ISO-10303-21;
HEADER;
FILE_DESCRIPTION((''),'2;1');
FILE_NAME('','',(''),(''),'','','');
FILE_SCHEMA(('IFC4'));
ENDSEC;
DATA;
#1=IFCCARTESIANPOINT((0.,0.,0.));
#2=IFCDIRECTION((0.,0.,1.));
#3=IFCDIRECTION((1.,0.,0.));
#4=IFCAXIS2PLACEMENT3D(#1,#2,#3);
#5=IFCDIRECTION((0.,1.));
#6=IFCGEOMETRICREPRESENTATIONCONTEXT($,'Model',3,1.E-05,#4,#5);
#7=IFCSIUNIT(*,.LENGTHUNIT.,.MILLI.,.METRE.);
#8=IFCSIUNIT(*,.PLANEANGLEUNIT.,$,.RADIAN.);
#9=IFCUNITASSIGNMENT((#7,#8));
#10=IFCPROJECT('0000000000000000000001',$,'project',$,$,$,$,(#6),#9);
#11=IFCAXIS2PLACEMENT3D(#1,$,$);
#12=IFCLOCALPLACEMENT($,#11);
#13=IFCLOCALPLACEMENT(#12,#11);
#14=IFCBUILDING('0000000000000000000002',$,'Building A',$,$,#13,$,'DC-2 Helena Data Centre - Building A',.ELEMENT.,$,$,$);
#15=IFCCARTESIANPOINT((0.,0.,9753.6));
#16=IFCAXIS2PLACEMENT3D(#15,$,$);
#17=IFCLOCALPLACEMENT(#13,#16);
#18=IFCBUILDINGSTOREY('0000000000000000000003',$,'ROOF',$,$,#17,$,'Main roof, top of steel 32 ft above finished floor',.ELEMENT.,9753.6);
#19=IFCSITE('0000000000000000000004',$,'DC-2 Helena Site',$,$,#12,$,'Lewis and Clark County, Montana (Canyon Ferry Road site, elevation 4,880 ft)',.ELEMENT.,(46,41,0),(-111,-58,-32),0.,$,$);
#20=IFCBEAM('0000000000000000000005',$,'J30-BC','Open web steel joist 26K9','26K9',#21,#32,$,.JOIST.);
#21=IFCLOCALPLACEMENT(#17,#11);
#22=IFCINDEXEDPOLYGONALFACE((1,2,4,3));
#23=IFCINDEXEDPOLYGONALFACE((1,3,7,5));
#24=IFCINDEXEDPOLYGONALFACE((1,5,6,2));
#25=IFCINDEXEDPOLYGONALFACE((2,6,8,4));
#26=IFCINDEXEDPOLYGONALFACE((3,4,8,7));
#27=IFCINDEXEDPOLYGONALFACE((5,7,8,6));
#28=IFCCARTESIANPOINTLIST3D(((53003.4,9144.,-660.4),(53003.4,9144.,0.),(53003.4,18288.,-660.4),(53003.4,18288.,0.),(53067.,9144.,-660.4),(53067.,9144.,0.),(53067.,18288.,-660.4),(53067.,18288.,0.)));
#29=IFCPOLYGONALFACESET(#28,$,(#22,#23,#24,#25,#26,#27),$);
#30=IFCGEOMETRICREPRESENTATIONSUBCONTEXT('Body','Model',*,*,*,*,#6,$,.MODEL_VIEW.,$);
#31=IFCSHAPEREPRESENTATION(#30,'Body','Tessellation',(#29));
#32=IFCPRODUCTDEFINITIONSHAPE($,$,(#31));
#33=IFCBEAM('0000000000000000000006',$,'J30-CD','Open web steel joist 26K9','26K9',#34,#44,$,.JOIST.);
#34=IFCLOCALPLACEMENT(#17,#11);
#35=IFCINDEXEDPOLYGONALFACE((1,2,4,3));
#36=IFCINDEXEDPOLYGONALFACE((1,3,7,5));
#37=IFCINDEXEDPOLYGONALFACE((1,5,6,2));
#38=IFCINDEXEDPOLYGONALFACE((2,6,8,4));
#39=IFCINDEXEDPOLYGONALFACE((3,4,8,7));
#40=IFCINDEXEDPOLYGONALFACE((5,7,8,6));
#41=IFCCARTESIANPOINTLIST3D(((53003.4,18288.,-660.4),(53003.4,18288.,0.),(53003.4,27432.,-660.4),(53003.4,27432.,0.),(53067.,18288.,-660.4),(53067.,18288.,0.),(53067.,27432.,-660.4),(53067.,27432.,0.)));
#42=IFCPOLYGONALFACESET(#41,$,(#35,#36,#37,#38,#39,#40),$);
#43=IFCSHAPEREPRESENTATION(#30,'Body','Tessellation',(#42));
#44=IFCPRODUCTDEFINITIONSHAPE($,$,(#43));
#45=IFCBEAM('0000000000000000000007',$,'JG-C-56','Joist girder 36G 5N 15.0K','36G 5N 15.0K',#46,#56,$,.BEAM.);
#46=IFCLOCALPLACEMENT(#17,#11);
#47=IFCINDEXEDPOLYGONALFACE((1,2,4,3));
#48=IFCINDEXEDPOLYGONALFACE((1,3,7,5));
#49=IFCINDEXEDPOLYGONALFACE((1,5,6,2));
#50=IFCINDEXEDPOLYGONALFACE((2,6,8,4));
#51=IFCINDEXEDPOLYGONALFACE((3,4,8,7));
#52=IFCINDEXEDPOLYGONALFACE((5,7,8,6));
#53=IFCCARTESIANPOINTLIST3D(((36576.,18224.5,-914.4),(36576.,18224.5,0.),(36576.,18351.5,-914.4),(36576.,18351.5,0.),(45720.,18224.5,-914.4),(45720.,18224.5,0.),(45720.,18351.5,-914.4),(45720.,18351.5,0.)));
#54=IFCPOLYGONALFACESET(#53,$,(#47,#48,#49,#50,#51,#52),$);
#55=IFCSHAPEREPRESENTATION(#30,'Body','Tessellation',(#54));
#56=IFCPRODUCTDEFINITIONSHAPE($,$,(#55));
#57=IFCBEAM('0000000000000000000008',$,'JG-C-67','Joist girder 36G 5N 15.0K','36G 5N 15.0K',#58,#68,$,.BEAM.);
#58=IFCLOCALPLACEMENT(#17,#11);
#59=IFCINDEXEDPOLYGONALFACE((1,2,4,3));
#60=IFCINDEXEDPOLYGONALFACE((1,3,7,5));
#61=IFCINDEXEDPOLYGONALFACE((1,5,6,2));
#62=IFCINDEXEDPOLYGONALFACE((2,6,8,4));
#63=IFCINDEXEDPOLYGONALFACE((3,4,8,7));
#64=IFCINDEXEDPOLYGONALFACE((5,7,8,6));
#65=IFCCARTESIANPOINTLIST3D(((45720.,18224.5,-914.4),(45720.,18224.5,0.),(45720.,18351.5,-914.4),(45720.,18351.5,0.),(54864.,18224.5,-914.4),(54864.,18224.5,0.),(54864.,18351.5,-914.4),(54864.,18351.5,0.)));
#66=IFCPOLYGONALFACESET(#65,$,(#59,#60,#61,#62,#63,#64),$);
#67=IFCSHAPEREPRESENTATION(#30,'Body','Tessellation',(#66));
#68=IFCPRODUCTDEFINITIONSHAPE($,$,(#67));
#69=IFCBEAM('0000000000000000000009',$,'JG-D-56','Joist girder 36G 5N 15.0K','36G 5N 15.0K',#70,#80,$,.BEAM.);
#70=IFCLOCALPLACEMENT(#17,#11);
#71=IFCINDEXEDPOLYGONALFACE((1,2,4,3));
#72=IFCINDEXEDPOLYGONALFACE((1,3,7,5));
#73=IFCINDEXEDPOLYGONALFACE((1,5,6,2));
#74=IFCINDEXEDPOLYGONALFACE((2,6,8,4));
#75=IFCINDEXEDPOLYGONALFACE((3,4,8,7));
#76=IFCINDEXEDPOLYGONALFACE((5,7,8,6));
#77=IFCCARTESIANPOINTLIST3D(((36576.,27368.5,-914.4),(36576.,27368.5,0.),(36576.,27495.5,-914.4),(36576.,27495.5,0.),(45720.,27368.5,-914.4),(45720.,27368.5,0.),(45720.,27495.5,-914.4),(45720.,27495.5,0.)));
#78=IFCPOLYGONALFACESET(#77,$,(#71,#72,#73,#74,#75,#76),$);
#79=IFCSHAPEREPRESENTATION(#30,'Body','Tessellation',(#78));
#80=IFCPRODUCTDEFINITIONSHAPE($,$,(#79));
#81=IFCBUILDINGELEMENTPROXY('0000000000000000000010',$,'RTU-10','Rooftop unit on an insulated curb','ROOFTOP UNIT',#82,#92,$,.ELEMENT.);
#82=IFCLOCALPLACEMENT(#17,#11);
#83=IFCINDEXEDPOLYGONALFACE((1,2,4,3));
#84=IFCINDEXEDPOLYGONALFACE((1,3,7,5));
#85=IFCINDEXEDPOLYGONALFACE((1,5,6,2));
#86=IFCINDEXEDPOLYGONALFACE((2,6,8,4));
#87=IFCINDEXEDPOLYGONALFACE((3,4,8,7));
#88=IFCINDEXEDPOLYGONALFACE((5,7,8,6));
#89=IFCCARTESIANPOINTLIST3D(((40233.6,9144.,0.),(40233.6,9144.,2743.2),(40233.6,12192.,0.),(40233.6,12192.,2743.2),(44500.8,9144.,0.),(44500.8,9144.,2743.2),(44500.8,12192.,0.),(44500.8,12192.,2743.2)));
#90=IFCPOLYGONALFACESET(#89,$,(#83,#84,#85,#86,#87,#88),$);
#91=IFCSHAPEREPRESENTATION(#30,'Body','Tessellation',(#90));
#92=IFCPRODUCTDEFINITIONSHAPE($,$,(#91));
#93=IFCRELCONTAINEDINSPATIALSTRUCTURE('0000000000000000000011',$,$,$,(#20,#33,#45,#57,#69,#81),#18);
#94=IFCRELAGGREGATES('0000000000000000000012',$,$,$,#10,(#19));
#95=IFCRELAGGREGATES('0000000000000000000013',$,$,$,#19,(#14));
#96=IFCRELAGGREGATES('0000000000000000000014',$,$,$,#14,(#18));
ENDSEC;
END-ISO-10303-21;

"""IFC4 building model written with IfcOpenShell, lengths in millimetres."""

from ifc_helpers import new_model, si_unit, direction, frame, origin, origin_with_axes, origin_2d, place, context, subcontext, project, spatial, rectangle, extrude, element, save


model = new_model("IFC4")

# Units and contexts
model_context = context("Model", 3, precision=1e-05, world=origin_with_axes(), true_north=direction((0.0, 1.0)))
body_context = subcontext(model_context, "Body", "Model", "MODEL_VIEW")
ifc_project = project(units=[si_unit("LENGTHUNIT", "METRE", prefix="MILLI"), si_unit("PLANEANGLEUNIT", "RADIAN")], contexts=[model_context])

# Site, building, storey
site_placement = place(None, origin())
site = spatial("IfcSite", under=ifc_project, at=site_placement, Name="DC-2 Helena Site", LongName="Lewis and Clark County, Montana (Canyon Ferry Road site, elevation 4,880 ft)", CompositionType="ELEMENT", RefLatitude=(46, 41, 0), RefLongitude=(-111, -58, -32), RefElevation=0.0)
building_placement = place(site_placement, origin())
building = spatial("IfcBuilding", under=site, at=building_placement, Name="Building A", LongName="DC-2 Helena Data Centre - Building A", CompositionType="ELEMENT")
storey_placement = place(building_placement, frame((0.0, 0.0, 9753.6)))
storey = spatial("IfcBuildingStorey", under=building, at=storey_placement, Name="ROOF", LongName="Main roof, top of steel 32 ft above finished floor", CompositionType="ELEMENT", Elevation=9753.6)

# Beams
placement = place(storey_placement, frame((45720.0, 18288.0, 0.0)))
for number, where, name in (
    (1, (53035.2, 9144.0, 0.0), "J30-BC"),
    (2, (53035.2, 18288.0, 0.0), "J30-CD"),
):
    element("IfcBeam", number, at=place(storey_placement, frame(where)), inside=storey, Name=name, Description="Open web steel joist 26K9", ObjectType="26K9", PredefinedType="JOIST", context=body_context, shape_type="SweptSolid", body=[
        extrude(rectangle(XDim=63.5, YDim=660.4, at=origin_2d()), frame((0.0, 0.0, -330.2), z_axis=(0.0, 1.0, 0.0), x_axis=(1.0, 0.0, 0.0)), (0.0, 0.0, 1.0), 9144.0),
    ])
beam_1_placement = place(storey_placement, frame((36576.0, 18288.0, 0.0)))
element("IfcBeam", 3, at=beam_1_placement, inside=storey, Name="JG-C-56", Description="Joist girder 36G 5N 15.0K", ObjectType="36G 5N 15.0K", PredefinedType="BEAM", context=body_context, shape_type="SweptSolid", body=[
    extrude(rectangle(XDim=127.0, YDim=914.4, at=origin_2d()), frame((0.0, 0.0, -457.2), z_axis=(1.0, 0.0, 0.0), x_axis=(0.0, 1.0, 0.0)), (0.0, 0.0, 1.0), 9144.0),
])
element("IfcBeam", 4, at=placement, inside=storey, Name="JG-C-67", Description="Joist girder 36G 5N 15.0K", ObjectType="36G 5N 15.0K", PredefinedType="BEAM", context=body_context, shape_type="SweptSolid", body=[
    extrude(rectangle(XDim=127.0, YDim=914.4, at=origin_2d()), frame((0.0, 0.0, -457.2), z_axis=(1.0, 0.0, 0.0), x_axis=(0.0, 1.0, 0.0)), (0.0, 0.0, 1.0), 9144.0),
])
beam_2_placement = place(storey_placement, frame((36576.0, 27432.0, 0.0)))
element("IfcBeam", 5, at=beam_2_placement, inside=storey, Name="JG-D-56", Description="Joist girder 36G 5N 15.0K", ObjectType="36G 5N 15.0K", PredefinedType="BEAM", context=body_context, shape_type="SweptSolid", body=[
    extrude(rectangle(XDim=127.0, YDim=914.4, at=origin_2d()), frame((0.0, 0.0, -457.2), z_axis=(1.0, 0.0, 0.0), x_axis=(0.0, 1.0, 0.0)), (0.0, 0.0, 1.0), 9144.0),
])

# Building element proxy
proxy_placement = place(storey_placement, frame((42367.2, 10668.0, 0.0)))
element("IfcBuildingElementProxy", 6, at=proxy_placement, inside=storey, Name="RTU-10", Description="Rooftop unit on an insulated curb", ObjectType="ROOFTOP UNIT", PredefinedType="ELEMENT", context=body_context, shape_type="SweptSolid", body=[
    extrude(rectangle(XDim=4267.2, YDim=3048.0, at=origin_2d()), origin(), (0.0, 0.0, 1.0), 2743.2),
])

save(model, "model.ifc")
